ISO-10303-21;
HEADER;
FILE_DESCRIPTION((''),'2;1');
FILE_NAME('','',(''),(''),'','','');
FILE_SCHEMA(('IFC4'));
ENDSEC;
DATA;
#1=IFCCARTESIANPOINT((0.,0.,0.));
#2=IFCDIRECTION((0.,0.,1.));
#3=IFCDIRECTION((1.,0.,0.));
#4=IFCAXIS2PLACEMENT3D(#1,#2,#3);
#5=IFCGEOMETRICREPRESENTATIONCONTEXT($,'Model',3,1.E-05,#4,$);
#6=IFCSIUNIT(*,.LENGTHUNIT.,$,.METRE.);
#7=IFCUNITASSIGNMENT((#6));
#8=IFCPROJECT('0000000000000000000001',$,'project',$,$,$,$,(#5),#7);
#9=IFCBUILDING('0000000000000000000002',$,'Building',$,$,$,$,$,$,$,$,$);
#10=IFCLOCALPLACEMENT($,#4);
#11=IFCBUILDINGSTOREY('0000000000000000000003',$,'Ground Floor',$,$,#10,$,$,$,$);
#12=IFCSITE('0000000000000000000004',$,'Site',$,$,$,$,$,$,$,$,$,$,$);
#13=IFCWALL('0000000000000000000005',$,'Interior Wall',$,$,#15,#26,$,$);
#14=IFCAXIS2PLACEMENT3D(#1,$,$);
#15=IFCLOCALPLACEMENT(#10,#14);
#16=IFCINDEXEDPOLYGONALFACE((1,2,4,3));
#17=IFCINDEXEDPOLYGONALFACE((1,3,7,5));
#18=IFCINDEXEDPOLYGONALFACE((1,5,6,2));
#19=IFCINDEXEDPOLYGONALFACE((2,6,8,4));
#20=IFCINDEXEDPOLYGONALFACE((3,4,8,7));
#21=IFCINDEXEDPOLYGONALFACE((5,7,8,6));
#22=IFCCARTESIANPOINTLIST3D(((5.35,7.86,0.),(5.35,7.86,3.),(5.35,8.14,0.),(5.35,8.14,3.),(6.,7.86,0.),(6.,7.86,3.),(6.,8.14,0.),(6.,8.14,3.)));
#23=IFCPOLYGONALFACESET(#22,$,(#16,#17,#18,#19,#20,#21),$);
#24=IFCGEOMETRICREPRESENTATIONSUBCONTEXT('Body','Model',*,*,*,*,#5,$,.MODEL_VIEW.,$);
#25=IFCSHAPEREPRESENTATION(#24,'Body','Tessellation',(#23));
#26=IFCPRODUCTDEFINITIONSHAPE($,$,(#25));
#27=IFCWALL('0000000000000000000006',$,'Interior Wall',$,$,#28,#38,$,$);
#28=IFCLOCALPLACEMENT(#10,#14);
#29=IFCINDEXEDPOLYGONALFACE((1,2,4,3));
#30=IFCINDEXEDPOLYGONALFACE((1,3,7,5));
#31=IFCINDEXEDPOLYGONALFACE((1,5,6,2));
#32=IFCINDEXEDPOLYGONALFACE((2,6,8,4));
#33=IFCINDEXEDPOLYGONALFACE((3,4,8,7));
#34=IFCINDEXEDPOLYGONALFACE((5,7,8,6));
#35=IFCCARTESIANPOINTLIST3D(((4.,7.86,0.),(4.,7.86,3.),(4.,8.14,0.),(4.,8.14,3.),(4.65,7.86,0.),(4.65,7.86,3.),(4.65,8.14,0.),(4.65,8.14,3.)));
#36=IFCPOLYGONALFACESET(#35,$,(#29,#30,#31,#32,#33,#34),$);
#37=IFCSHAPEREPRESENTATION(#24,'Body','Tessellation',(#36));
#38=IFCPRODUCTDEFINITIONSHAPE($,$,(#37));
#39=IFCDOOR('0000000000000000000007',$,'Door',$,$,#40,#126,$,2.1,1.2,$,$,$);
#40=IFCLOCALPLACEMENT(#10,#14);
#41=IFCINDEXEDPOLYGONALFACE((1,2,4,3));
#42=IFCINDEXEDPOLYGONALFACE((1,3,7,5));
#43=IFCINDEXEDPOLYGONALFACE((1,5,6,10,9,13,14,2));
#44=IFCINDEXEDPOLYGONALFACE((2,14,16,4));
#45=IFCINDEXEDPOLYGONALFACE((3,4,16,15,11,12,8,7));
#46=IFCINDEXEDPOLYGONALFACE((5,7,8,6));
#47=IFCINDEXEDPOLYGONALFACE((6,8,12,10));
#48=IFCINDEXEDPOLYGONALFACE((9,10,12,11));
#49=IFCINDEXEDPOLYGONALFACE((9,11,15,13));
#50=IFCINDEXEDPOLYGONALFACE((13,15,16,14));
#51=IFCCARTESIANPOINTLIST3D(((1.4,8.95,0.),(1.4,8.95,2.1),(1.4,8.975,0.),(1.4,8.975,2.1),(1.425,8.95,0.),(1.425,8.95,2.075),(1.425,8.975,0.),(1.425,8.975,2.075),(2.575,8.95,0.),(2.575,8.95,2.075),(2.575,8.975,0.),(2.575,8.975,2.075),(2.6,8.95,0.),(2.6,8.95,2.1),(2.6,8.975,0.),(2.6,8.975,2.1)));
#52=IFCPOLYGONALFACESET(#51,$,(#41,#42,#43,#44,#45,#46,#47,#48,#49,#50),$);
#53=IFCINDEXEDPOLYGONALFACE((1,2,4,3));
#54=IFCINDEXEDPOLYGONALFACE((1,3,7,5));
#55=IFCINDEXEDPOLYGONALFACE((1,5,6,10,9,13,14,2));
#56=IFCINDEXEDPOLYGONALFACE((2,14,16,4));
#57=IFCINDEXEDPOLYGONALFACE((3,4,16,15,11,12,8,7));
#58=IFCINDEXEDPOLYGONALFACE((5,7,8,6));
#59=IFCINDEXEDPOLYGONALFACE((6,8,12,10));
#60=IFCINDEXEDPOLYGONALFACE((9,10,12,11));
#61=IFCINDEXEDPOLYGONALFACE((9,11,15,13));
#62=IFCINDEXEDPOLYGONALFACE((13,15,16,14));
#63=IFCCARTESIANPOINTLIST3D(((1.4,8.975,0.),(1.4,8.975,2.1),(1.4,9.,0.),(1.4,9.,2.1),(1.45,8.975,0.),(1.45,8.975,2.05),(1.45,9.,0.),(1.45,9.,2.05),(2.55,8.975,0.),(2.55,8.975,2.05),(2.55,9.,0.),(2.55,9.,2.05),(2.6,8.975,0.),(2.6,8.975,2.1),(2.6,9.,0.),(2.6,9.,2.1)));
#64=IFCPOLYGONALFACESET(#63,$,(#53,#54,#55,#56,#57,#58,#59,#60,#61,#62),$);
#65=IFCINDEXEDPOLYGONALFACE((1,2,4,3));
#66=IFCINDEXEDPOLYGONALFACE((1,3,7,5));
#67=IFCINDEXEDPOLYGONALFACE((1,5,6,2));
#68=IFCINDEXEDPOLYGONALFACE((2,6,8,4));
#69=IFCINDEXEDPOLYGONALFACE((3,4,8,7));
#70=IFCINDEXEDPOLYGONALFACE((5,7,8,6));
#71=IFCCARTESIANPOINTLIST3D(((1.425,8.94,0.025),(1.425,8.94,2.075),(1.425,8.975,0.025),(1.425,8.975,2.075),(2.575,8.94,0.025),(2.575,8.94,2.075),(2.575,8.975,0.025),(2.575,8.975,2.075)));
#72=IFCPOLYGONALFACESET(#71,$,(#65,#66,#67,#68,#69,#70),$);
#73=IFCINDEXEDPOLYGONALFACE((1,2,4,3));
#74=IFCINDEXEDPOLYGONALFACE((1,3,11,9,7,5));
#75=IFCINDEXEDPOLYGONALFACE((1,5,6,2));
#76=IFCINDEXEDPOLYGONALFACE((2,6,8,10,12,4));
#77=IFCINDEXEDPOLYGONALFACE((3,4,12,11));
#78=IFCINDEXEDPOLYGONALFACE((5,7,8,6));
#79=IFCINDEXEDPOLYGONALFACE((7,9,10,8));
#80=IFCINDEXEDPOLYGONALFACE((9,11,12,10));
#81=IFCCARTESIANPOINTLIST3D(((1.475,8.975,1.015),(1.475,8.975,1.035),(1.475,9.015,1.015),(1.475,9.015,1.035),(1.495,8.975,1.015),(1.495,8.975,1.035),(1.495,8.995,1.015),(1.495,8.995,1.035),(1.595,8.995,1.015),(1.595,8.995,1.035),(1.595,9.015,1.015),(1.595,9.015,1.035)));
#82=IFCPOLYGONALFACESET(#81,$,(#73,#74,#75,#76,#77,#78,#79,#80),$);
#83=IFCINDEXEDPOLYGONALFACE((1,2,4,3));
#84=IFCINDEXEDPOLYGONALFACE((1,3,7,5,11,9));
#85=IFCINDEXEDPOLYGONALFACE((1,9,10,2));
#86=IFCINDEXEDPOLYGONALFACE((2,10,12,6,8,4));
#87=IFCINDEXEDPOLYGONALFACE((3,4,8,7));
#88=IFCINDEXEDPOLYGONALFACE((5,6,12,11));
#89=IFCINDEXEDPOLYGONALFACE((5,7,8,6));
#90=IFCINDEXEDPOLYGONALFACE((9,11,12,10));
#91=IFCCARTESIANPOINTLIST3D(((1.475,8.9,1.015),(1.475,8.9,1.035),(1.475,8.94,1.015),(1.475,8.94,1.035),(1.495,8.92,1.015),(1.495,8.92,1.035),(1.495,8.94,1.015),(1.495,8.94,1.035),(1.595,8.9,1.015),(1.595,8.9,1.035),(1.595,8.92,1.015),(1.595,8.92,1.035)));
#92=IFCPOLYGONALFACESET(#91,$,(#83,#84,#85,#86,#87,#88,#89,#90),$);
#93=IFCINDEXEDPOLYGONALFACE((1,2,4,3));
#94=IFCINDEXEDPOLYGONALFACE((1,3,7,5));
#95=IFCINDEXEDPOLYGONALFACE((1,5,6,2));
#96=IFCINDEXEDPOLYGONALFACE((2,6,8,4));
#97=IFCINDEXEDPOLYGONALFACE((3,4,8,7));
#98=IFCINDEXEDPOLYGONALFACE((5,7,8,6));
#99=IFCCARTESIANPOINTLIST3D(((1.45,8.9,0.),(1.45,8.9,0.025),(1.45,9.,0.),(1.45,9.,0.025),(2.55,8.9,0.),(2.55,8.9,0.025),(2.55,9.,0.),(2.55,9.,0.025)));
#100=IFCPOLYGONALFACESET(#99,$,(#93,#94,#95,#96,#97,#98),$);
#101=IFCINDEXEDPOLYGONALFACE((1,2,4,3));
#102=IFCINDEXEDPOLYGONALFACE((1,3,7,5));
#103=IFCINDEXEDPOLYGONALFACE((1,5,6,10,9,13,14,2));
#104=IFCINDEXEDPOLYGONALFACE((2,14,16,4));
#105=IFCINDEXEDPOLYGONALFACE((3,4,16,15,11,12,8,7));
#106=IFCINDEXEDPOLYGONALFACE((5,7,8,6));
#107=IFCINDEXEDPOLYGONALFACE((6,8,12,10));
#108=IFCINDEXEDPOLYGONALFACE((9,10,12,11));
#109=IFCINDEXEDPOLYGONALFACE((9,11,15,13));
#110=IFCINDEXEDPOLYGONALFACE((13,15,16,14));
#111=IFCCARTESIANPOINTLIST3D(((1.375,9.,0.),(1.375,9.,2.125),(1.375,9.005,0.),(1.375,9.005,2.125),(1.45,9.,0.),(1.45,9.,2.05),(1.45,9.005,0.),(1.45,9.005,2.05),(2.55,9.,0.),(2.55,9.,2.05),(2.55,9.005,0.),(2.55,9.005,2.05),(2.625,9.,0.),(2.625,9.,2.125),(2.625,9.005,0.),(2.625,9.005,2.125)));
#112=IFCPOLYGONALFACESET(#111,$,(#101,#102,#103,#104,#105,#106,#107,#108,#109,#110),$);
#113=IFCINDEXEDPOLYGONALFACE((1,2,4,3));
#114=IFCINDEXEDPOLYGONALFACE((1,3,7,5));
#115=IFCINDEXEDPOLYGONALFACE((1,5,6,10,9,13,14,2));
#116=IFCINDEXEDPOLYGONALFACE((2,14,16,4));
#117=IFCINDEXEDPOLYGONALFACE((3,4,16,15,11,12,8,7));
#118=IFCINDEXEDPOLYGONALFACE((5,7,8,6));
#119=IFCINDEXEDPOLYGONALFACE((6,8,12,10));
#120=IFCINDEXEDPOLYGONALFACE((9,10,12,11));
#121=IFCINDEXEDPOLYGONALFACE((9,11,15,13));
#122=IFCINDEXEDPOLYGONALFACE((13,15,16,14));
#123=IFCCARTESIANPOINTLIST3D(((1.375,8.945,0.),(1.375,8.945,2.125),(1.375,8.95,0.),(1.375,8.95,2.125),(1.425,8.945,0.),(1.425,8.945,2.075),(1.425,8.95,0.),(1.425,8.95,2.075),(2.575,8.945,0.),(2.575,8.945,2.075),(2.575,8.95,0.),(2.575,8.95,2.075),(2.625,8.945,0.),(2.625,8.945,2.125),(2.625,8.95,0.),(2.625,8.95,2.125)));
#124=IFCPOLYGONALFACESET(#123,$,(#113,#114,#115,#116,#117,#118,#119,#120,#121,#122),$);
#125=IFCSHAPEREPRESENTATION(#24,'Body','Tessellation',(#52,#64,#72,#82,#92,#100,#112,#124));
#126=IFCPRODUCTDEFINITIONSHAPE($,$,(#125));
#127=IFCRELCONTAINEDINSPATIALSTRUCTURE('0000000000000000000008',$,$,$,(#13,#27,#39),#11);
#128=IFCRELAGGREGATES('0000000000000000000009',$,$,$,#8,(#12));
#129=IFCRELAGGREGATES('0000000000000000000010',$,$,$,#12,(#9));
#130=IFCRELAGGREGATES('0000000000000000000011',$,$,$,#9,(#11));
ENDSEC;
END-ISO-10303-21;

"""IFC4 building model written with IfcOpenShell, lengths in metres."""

from ifc_helpers import new_model, si_unit, frame, origin_with_axes, place, context, subcontext, project, spatial, line, indexed_curve, outline, extrude, element, save


model = new_model("IFC4")

# Units and contexts
model_context = context("Model", 3, precision=1e-05, world=origin_with_axes())
body_context = subcontext(model_context, "Body", "Model", "MODEL_VIEW")
ifc_project = project(units=[si_unit("LENGTHUNIT", "METRE")], contexts=[model_context])

# Site, building, storey
site = spatial("IfcSite", under=ifc_project, Name="Site")
building = spatial("IfcBuilding", under=site, Name="Building")
storey_placement = place(None, origin_with_axes())
storey = spatial("IfcBuildingStorey", under=building, at=storey_placement, Name="Ground Floor")

# Walls
for number, where, z_axis, x_axis, name in (
    (1, (6.0, 8.0, 0.0), (0.0, 0.0, 1.0), (-1.0, 0.0, 0.0), "Interior Wall"),
    (2, (4.65, 8.0, 0.0), (0.0, 0.0, 1.0), (-1.0, 0.0, 0.0), "Interior Wall"),
):
    element("IfcWall", number, at=place(storey_placement, frame(where, z_axis=z_axis, x_axis=x_axis)), inside=storey, Name=name, context=body_context, shape_type="SweptSolid", body=[
        extrude(outline(indexed_curve([(0.0, 0.0), (0.0, 0.28), (0.65, 0.28), (0.65, 0.0), (0.0, 0.0)], self_intersect=False)), frame((0.0, -0.14, 0.0), z_axis=(0.0, 0.0, 1.0), x_axis=(1.0, 0.0, 0.0)), (0.0, 0.0, 1.0), 3.0),
    ])

# Door
door_1_placement = place(storey_placement, frame((2.6, 9.0, 0.0), z_axis=(0.0, 0.0, 1.0), x_axis=(-1.0, 0.0, 0.0)))
element("IfcDoor", 3, at=door_1_placement, inside=storey, Name="Door", OverallHeight=2.1, OverallWidth=1.2, context=body_context, shape_type="SweptSolid", body=[
    extrude(outline(indexed_curve([(0.0, 0.0), (0.0, 2.1), (1.2, 2.1), (1.2, 0.0), (1.175, 0.0), (1.175, 2.075), (0.025, 2.075), (0.025, 0.0)], segments=[line(1, 2, 3, 4, 5, 6, 7, 8, 1)])), frame((0.0, 0.025, 0.0), z_axis=(0.0, -1.0, 0.0), x_axis=(1.0, 0.0, 0.0)), (0.0, 0.0, -1.0), 0.025),
    extrude(outline(indexed_curve([(0.0, 0.0), (0.0, 2.1), (1.2, 2.1), (1.2, 0.0), (1.15, 0.0), (1.15, 2.05), (0.05, 2.05), (0.05, 0.0)], segments=[line(1, 2, 3, 4, 5, 6, 7, 8, 1)])), frame((0.0, 0.0, 0.0), z_axis=(0.0, -1.0, 0.0), x_axis=(1.0, 0.0, 0.0)), (0.0, 0.0, -1.0), 0.025),
    extrude(outline(indexed_curve([(0.0, 0.0), (1.15, 0.0), (1.15, 0.035), (0.0, 0.035)], segments=[line(1, 2, 3, 4, 1)])), frame((0.025, 0.025, 0.025), z_axis=(0.0, 0.0, 1.0), x_axis=(1.0, 0.0, 0.0)), (0.0, 0.0, 1.0), 2.05),
    extrude(outline(indexed_curve([(0.0, 0.0), (0.0, -0.04), (-0.12, -0.04), (-0.12, -0.02), (-0.02, -0.02), (-0.02, 0.0)], segments=[line(1, 2, 3, 4, 5, 6, 1)])), frame((1.125, 0.025, 1.015), z_axis=(0.0, 0.0, 1.0), x_axis=(1.0, 0.0, 0.0)), (0.0, 0.0, 1.0), 0.02),
    extrude(outline(indexed_curve([(0.0, 0.0), (0.0, 0.04), (-0.12, 0.04), (-0.12, 0.02), (-0.02, 0.02), (-0.02, 0.0)], segments=[line(1, 2, 3, 4, 5, 6, 1)])), frame((1.125, 0.06, 1.015), z_axis=(0.0, 0.0, 1.0), x_axis=(1.0, 0.0, 0.0)), (0.0, 0.0, 1.0), 0.02),
    extrude(outline(indexed_curve([(0.0, 0.0), (1.1, 0.0), (1.1, 0.1), (0.0, 0.1)], segments=[line(1, 2, 3, 4, 1)])), frame((0.05, 0.0, 0.0), z_axis=(0.0, 0.0, 1.0), x_axis=(1.0, 0.0, 0.0)), (0.0, 0.0, 1.0), 0.025),
    extrude(outline(indexed_curve([(0.0, 0.0), (0.0, 2.125), (1.25, 2.125), (1.25, 0.0), (1.175, 0.0), (1.175, 2.05), (0.075, 2.05), (0.075, 0.0)], segments=[line(1, 2, 3, 4, 5, 6, 7, 8, 1)])), frame((-0.025, -0.005, 0.0), z_axis=(0.0, -1.0, 0.0), x_axis=(1.0, 0.0, 0.0)), (0.0, 0.0, -1.0), 0.005),
    extrude(outline(indexed_curve([(0.0, 0.0), (0.0, 2.125), (1.25, 2.125), (1.25, 0.0), (1.2, 0.0), (1.2, 2.075), (0.05, 2.075), (0.05, 0.0)], segments=[line(1, 2, 3, 4, 5, 6, 7, 8, 1)])), frame((-0.025, 0.05, 0.0), z_axis=(0.0, -1.0, 0.0), x_axis=(1.0, 0.0, 0.0)), (0.0, 0.0, -1.0), 0.005),
])

save(model, "model.ifc")
